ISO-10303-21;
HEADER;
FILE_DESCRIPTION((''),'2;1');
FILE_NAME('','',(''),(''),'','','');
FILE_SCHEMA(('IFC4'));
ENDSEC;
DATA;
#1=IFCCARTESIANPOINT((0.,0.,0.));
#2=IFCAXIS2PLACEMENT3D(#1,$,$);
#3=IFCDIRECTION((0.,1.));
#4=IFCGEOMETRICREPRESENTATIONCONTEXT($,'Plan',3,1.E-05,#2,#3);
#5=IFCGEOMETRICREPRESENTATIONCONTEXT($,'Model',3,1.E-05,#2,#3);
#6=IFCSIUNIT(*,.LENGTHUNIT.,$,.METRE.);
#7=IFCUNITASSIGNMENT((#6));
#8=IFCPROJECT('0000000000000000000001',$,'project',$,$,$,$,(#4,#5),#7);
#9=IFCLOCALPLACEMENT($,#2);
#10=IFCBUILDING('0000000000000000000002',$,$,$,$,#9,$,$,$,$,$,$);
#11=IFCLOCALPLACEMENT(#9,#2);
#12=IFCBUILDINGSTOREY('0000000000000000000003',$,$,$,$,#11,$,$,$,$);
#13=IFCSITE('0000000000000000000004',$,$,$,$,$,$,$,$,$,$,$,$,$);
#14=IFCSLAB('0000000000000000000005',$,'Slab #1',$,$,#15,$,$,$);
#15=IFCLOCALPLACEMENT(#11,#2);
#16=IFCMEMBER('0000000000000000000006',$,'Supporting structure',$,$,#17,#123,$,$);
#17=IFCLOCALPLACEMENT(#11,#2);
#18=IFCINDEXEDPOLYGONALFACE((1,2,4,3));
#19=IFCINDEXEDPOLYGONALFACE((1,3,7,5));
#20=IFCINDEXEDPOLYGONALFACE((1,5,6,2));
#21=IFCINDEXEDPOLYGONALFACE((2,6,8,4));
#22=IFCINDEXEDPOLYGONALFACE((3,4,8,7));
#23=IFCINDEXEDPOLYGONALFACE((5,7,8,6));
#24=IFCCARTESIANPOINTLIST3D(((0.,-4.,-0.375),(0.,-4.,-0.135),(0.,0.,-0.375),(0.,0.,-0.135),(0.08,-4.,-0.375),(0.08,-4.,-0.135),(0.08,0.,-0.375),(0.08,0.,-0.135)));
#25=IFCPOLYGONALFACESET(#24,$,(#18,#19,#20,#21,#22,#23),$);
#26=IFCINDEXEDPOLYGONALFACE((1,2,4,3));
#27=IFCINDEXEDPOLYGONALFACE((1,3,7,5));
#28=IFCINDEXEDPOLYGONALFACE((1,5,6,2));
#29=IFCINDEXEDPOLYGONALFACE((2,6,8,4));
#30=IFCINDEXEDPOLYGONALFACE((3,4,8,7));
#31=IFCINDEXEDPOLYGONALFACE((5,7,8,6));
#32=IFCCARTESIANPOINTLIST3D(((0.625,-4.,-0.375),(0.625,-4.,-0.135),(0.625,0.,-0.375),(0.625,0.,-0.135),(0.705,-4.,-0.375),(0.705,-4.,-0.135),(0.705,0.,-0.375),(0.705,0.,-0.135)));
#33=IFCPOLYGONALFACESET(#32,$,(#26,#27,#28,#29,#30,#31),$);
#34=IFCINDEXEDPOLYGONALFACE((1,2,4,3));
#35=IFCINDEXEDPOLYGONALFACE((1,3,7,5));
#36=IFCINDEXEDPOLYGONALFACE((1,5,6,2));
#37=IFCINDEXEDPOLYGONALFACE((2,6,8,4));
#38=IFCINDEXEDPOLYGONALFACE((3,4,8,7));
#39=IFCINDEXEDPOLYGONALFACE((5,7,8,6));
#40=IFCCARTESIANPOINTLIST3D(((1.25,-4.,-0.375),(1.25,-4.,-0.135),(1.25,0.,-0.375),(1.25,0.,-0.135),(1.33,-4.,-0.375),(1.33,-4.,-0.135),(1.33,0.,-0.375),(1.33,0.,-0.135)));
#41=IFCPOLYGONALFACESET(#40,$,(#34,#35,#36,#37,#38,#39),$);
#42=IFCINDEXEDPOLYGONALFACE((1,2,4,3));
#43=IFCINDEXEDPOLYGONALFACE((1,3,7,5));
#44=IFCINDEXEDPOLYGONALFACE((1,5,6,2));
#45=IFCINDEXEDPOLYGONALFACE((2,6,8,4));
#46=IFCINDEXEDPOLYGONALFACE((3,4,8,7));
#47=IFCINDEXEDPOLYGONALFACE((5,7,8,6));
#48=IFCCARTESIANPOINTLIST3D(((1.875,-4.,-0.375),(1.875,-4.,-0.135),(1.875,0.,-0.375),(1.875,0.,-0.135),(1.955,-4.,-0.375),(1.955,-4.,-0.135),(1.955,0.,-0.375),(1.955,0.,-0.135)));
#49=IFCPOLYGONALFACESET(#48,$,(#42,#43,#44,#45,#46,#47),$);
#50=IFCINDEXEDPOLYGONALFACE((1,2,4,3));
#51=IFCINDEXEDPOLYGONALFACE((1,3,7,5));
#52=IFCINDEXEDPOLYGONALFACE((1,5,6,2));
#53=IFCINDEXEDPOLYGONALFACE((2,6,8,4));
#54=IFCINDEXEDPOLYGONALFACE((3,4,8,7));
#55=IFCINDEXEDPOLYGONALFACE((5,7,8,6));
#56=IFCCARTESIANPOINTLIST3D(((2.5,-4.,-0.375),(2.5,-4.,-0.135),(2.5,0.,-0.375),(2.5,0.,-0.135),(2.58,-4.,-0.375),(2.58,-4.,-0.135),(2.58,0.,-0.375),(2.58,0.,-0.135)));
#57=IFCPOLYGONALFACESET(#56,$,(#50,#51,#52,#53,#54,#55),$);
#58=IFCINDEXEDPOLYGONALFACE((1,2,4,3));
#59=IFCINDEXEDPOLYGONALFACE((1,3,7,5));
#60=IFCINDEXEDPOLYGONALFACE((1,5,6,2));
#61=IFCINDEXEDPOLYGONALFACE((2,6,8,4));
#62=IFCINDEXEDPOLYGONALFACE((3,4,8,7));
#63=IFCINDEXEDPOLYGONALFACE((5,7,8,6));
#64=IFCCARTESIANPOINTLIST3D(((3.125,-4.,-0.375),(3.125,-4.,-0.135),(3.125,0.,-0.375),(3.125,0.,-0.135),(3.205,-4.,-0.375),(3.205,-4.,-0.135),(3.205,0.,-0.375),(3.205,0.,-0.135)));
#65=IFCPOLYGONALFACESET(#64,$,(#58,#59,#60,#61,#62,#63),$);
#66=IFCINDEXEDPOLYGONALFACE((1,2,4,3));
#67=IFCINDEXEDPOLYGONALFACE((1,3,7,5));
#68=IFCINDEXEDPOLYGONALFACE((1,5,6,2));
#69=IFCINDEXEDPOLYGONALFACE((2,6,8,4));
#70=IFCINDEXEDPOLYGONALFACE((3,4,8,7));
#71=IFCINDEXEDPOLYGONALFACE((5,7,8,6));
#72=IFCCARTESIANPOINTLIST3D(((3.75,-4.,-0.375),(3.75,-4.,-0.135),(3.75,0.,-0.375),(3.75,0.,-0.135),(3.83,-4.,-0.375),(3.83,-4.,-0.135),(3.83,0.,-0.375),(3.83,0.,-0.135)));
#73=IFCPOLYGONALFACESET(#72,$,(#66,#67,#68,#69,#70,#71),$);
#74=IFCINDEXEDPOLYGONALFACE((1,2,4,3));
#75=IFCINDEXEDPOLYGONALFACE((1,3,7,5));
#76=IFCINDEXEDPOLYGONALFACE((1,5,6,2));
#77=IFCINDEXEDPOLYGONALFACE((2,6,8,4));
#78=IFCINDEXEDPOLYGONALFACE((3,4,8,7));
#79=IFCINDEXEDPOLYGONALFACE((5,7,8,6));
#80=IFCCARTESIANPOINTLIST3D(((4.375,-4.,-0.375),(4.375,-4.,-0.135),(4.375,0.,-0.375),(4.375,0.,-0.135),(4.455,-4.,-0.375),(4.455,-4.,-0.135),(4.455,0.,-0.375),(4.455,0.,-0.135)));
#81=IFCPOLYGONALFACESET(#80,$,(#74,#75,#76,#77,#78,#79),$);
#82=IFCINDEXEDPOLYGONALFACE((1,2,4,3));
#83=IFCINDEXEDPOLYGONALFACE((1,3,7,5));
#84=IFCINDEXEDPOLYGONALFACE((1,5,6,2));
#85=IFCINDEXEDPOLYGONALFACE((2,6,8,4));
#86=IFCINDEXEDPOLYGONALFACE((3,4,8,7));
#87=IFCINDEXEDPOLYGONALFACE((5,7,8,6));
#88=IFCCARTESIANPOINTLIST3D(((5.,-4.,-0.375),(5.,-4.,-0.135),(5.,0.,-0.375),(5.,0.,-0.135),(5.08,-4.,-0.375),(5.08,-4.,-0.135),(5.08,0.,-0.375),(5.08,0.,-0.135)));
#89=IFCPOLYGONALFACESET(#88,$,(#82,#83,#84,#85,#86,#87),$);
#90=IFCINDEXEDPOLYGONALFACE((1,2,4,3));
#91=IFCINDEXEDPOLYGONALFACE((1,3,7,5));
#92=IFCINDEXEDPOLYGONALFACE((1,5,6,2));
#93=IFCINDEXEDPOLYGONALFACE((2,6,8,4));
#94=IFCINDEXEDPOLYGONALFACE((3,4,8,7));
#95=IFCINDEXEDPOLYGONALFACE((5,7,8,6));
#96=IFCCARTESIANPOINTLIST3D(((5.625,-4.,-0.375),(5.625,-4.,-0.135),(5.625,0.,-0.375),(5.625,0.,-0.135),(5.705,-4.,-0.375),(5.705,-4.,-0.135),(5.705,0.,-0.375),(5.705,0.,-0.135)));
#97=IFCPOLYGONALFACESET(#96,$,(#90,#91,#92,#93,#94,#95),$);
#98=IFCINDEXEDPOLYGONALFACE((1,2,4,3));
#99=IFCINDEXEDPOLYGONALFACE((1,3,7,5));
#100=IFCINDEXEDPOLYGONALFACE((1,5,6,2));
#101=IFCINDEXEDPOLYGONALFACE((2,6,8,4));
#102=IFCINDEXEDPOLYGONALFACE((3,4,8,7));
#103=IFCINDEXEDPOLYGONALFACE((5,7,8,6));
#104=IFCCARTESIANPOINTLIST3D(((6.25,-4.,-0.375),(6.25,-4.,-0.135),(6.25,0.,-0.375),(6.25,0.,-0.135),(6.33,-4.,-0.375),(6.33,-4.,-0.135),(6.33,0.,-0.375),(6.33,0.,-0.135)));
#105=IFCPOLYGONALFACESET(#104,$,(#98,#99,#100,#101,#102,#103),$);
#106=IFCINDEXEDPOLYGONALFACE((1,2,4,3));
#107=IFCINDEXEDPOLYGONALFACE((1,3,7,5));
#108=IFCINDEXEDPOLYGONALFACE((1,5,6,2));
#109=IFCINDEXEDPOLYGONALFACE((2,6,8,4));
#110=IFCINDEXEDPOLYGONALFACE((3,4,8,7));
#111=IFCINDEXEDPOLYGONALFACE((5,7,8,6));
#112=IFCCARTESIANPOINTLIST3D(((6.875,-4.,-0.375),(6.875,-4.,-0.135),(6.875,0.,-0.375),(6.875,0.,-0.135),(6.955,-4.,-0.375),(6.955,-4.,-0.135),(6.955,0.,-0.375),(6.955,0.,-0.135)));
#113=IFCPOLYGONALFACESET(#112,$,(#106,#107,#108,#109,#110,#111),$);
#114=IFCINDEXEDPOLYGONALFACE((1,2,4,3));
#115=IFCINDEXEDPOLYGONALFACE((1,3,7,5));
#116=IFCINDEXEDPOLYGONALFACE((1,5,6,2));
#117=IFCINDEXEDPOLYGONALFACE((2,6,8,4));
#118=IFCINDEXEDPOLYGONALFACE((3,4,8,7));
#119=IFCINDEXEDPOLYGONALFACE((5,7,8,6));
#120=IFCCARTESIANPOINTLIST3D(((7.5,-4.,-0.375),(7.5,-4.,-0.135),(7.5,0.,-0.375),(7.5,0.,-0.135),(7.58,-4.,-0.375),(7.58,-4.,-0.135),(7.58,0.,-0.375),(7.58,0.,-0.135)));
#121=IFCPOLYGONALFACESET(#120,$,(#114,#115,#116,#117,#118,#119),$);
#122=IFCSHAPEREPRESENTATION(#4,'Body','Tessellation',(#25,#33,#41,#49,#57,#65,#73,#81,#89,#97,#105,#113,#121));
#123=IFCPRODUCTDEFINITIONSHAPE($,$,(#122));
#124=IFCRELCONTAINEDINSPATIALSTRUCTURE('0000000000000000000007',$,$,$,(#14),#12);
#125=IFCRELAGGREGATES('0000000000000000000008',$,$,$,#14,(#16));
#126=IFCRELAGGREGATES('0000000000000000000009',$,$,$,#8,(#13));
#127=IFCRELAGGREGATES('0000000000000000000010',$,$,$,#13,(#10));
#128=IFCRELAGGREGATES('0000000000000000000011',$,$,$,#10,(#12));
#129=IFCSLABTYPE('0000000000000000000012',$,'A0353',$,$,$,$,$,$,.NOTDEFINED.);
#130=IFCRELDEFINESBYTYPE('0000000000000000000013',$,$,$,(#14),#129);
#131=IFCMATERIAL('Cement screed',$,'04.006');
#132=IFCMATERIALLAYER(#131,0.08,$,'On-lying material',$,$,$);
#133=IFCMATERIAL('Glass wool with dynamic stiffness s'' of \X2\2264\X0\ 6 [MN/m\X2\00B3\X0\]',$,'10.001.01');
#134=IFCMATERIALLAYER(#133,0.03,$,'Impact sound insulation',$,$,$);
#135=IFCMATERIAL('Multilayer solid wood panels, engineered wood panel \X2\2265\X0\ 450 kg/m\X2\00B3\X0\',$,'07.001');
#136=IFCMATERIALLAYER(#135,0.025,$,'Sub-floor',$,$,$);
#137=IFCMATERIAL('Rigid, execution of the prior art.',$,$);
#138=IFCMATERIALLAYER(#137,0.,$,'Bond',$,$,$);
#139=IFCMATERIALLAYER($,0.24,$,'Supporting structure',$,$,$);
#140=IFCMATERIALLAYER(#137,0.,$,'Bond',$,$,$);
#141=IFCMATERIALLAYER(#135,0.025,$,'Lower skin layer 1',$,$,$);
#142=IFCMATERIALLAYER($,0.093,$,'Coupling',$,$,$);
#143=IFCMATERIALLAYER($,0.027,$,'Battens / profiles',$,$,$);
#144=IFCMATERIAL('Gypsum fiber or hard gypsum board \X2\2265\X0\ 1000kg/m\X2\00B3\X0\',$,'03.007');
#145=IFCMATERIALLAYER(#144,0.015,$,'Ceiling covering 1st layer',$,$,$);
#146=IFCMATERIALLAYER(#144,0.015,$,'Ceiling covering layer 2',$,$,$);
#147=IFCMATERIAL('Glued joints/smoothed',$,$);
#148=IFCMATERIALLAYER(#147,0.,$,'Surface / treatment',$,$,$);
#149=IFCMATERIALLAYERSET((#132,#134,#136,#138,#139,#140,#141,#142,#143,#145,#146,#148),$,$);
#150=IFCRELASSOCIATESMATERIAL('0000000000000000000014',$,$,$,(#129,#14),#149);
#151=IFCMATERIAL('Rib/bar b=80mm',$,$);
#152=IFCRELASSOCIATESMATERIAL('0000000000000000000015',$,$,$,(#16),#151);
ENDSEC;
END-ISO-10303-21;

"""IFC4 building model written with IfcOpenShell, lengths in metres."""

from ifc_helpers import new_model, si_unit, direction, frame, frame_2d, origin, place, context, project, spatial, rectangle, extrude, material, layer, layer_set, type_object, element, aggregate, save


model = new_model("IFC4")

# Units and contexts
plan_context = context("Plan", 3, precision=1e-05, world=origin(), true_north=direction((0.0, 1.0)))
model_context = context("Model", 3, precision=1e-05, world=origin(), true_north=direction((0.0, 1.0)))
ifc_project = project(units=[si_unit("LENGTHUNIT", "METRE")], contexts=[plan_context, model_context])

# Site, building, storey
site = spatial("IfcSite", under=ifc_project)
building_placement = place(None, origin())
building = spatial("IfcBuilding", under=site, at=building_placement)
storey_placement = place(building_placement, origin())
storey = spatial("IfcBuildingStorey", under=building, at=storey_placement)

# Slab, member
ifc_material_1 = material(Name="Cement screed", Category="04.006")
ifc_layer_1 = layer(ifc_material_1, 0.08, Name="On-lying material")
ifc_material_2 = material(Name="Glass wool with dynamic stiffness s' of ≤ 6 [MN/m³]", Category="10.001.01")
ifc_layer_2 = layer(ifc_material_2, 0.03, Name="Impact sound insulation")
ifc_material_3 = material(Name="Multilayer solid wood panels, engineered wood panel ≥ 450 kg/m³", Category="07.001")
ifc_layer_3 = layer(ifc_material_3, 0.025, Name="Sub-floor")
ifc_material_4 = material(Name="Rigid, execution of the prior art.")
ifc_layer_4 = layer(ifc_material_4, 0.0, Name="Bond")
ifc_layer_5 = layer(None, 0.24, Name="Supporting structure")
ifc_layer_6 = layer(ifc_material_4, 0.0, Name="Bond")
ifc_layer_7 = layer(ifc_material_3, 0.025, Name="Lower skin layer 1")
ifc_layer_8 = layer(None, 0.093, Name="Coupling")
ifc_layer_9 = layer(None, 0.027, Name="Battens / profiles")
ifc_material_5 = material(Name="Gypsum fiber or hard gypsum board ≥ 1000kg/m³", Category="03.007")
ifc_layer_10 = layer(ifc_material_5, 0.015, Name="Ceiling covering 1st layer")
ifc_layer_11 = layer(ifc_material_5, 0.015, Name="Ceiling covering layer 2")
ifc_material_6 = material(Name="Glued joints/smoothed")
ifc_layer_12 = layer(ifc_material_6, 0.0, Name="Surface / treatment")
ifc_layer_set = layer_set([ifc_layer_1, ifc_layer_2, ifc_layer_3, ifc_layer_4, ifc_layer_5, ifc_layer_6, ifc_layer_7, ifc_layer_8, ifc_layer_9, ifc_layer_10, ifc_layer_11, ifc_layer_12])
slab_type = type_object("IfcSlabType", Name="A0353", PredefinedType="NOTDEFINED", material=ifc_layer_set)
slab_placement = place(None, frame((0.0, 0.0, 0.0), z_axis=(0.0, 0.0, -1.0), x_axis=(1.0, 0.0, 0.0)))
slab = element("IfcSlab", 1, at=slab_placement, inside=storey, type_object=slab_type, material=ifc_layer_set, Name="Slab #1")
ifc_material_7 = material(Name="Rib/bar b=80mm")
member_1_placement = place(slab_placement, origin())
member_1 = element("IfcMember", 2, at=member_1_placement, material=ifc_material_7, Name="Supporting structure", context=plan_context, shape_type="SweptSolid", body=[
    extrude(rectangle(XDim=0.08, YDim=0.24, at=frame_2d((0.04, 0.12), x_axis=(1.0, 0.0))), frame((0.0, 4.0, 0.135), z_axis=(0.0, -1.0, 0.0), x_axis=(1.0, 0.0, 0.0)), (0.0, 0.0, 1.0), 4.0),
    extrude(rectangle(XDim=0.08, YDim=0.24, at=frame_2d((0.04, 0.12), x_axis=(1.0, 0.0))), frame((0.625, 4.0, 0.135), z_axis=(0.0, -1.0, 0.0), x_axis=(1.0, 0.0, 0.0)), (0.0, 0.0, 1.0), 4.0),
    extrude(rectangle(XDim=0.08, YDim=0.24, at=frame_2d((0.04, 0.12), x_axis=(1.0, 0.0))), frame((1.25, 4.0, 0.135), z_axis=(0.0, -1.0, 0.0), x_axis=(1.0, 0.0, 0.0)), (0.0, 0.0, 1.0), 4.0),
    extrude(rectangle(XDim=0.08, YDim=0.24, at=frame_2d((0.04, 0.12), x_axis=(1.0, 0.0))), frame((1.875, 4.0, 0.135), z_axis=(0.0, -1.0, 0.0), x_axis=(1.0, 0.0, 0.0)), (0.0, 0.0, 1.0), 4.0),
    extrude(rectangle(XDim=0.08, YDim=0.24, at=frame_2d((0.04, 0.12), x_axis=(1.0, 0.0))), frame((2.5, 4.0, 0.135), z_axis=(0.0, -1.0, 0.0), x_axis=(1.0, 0.0, 0.0)), (0.0, 0.0, 1.0), 4.0),
    extrude(rectangle(XDim=0.08, YDim=0.24, at=frame_2d((0.04, 0.12), x_axis=(1.0, 0.0))), frame((3.125, 4.0, 0.135), z_axis=(0.0, -1.0, 0.0), x_axis=(1.0, 0.0, 0.0)), (0.0, 0.0, 1.0), 4.0),
    extrude(rectangle(XDim=0.08, YDim=0.24, at=frame_2d((0.04, 0.12), x_axis=(1.0, 0.0))), frame((3.75, 4.0, 0.135), z_axis=(0.0, -1.0, 0.0), x_axis=(1.0, 0.0, 0.0)), (0.0, 0.0, 1.0), 4.0),
    extrude(rectangle(XDim=0.08, YDim=0.24, at=frame_2d((0.04, 0.12), x_axis=(1.0, 0.0))), frame((4.375, 4.0, 0.135), z_axis=(0.0, -1.0, 0.0), x_axis=(1.0, 0.0, 0.0)), (0.0, 0.0, 1.0), 4.0),
    extrude(rectangle(XDim=0.08, YDim=0.24, at=frame_2d((0.04, 0.12), x_axis=(1.0, 0.0))), frame((5.0, 4.0, 0.135), z_axis=(0.0, -1.0, 0.0), x_axis=(1.0, 0.0, 0.0)), (0.0, 0.0, 1.0), 4.0),
    extrude(rectangle(XDim=0.08, YDim=0.24, at=frame_2d((0.04, 0.12), x_axis=(1.0, 0.0))), frame((5.625, 4.0, 0.135), z_axis=(0.0, -1.0, 0.0), x_axis=(1.0, 0.0, 0.0)), (0.0, 0.0, 1.0), 4.0),
    extrude(rectangle(XDim=0.08, YDim=0.24, at=frame_2d((0.04, 0.12), x_axis=(1.0, 0.0))), frame((6.25, 4.0, 0.135), z_axis=(0.0, -1.0, 0.0), x_axis=(1.0, 0.0, 0.0)), (0.0, 0.0, 1.0), 4.0),
    extrude(rectangle(XDim=0.08, YDim=0.24, at=frame_2d((0.04, 0.12), x_axis=(1.0, 0.0))), frame((6.875, 4.0, 0.135), z_axis=(0.0, -1.0, 0.0), x_axis=(1.0, 0.0, 0.0)), (0.0, 0.0, 1.0), 4.0),
    extrude(rectangle(XDim=0.08, YDim=0.24, at=frame_2d((0.04, 0.12), x_axis=(1.0, 0.0))), frame((7.5, 4.0, 0.135), z_axis=(0.0, -1.0, 0.0), x_axis=(1.0, 0.0, 0.0)), (0.0, 0.0, 1.0), 4.0),
])
aggregate(slab, [member_1])

save(model, "model.ifc")
